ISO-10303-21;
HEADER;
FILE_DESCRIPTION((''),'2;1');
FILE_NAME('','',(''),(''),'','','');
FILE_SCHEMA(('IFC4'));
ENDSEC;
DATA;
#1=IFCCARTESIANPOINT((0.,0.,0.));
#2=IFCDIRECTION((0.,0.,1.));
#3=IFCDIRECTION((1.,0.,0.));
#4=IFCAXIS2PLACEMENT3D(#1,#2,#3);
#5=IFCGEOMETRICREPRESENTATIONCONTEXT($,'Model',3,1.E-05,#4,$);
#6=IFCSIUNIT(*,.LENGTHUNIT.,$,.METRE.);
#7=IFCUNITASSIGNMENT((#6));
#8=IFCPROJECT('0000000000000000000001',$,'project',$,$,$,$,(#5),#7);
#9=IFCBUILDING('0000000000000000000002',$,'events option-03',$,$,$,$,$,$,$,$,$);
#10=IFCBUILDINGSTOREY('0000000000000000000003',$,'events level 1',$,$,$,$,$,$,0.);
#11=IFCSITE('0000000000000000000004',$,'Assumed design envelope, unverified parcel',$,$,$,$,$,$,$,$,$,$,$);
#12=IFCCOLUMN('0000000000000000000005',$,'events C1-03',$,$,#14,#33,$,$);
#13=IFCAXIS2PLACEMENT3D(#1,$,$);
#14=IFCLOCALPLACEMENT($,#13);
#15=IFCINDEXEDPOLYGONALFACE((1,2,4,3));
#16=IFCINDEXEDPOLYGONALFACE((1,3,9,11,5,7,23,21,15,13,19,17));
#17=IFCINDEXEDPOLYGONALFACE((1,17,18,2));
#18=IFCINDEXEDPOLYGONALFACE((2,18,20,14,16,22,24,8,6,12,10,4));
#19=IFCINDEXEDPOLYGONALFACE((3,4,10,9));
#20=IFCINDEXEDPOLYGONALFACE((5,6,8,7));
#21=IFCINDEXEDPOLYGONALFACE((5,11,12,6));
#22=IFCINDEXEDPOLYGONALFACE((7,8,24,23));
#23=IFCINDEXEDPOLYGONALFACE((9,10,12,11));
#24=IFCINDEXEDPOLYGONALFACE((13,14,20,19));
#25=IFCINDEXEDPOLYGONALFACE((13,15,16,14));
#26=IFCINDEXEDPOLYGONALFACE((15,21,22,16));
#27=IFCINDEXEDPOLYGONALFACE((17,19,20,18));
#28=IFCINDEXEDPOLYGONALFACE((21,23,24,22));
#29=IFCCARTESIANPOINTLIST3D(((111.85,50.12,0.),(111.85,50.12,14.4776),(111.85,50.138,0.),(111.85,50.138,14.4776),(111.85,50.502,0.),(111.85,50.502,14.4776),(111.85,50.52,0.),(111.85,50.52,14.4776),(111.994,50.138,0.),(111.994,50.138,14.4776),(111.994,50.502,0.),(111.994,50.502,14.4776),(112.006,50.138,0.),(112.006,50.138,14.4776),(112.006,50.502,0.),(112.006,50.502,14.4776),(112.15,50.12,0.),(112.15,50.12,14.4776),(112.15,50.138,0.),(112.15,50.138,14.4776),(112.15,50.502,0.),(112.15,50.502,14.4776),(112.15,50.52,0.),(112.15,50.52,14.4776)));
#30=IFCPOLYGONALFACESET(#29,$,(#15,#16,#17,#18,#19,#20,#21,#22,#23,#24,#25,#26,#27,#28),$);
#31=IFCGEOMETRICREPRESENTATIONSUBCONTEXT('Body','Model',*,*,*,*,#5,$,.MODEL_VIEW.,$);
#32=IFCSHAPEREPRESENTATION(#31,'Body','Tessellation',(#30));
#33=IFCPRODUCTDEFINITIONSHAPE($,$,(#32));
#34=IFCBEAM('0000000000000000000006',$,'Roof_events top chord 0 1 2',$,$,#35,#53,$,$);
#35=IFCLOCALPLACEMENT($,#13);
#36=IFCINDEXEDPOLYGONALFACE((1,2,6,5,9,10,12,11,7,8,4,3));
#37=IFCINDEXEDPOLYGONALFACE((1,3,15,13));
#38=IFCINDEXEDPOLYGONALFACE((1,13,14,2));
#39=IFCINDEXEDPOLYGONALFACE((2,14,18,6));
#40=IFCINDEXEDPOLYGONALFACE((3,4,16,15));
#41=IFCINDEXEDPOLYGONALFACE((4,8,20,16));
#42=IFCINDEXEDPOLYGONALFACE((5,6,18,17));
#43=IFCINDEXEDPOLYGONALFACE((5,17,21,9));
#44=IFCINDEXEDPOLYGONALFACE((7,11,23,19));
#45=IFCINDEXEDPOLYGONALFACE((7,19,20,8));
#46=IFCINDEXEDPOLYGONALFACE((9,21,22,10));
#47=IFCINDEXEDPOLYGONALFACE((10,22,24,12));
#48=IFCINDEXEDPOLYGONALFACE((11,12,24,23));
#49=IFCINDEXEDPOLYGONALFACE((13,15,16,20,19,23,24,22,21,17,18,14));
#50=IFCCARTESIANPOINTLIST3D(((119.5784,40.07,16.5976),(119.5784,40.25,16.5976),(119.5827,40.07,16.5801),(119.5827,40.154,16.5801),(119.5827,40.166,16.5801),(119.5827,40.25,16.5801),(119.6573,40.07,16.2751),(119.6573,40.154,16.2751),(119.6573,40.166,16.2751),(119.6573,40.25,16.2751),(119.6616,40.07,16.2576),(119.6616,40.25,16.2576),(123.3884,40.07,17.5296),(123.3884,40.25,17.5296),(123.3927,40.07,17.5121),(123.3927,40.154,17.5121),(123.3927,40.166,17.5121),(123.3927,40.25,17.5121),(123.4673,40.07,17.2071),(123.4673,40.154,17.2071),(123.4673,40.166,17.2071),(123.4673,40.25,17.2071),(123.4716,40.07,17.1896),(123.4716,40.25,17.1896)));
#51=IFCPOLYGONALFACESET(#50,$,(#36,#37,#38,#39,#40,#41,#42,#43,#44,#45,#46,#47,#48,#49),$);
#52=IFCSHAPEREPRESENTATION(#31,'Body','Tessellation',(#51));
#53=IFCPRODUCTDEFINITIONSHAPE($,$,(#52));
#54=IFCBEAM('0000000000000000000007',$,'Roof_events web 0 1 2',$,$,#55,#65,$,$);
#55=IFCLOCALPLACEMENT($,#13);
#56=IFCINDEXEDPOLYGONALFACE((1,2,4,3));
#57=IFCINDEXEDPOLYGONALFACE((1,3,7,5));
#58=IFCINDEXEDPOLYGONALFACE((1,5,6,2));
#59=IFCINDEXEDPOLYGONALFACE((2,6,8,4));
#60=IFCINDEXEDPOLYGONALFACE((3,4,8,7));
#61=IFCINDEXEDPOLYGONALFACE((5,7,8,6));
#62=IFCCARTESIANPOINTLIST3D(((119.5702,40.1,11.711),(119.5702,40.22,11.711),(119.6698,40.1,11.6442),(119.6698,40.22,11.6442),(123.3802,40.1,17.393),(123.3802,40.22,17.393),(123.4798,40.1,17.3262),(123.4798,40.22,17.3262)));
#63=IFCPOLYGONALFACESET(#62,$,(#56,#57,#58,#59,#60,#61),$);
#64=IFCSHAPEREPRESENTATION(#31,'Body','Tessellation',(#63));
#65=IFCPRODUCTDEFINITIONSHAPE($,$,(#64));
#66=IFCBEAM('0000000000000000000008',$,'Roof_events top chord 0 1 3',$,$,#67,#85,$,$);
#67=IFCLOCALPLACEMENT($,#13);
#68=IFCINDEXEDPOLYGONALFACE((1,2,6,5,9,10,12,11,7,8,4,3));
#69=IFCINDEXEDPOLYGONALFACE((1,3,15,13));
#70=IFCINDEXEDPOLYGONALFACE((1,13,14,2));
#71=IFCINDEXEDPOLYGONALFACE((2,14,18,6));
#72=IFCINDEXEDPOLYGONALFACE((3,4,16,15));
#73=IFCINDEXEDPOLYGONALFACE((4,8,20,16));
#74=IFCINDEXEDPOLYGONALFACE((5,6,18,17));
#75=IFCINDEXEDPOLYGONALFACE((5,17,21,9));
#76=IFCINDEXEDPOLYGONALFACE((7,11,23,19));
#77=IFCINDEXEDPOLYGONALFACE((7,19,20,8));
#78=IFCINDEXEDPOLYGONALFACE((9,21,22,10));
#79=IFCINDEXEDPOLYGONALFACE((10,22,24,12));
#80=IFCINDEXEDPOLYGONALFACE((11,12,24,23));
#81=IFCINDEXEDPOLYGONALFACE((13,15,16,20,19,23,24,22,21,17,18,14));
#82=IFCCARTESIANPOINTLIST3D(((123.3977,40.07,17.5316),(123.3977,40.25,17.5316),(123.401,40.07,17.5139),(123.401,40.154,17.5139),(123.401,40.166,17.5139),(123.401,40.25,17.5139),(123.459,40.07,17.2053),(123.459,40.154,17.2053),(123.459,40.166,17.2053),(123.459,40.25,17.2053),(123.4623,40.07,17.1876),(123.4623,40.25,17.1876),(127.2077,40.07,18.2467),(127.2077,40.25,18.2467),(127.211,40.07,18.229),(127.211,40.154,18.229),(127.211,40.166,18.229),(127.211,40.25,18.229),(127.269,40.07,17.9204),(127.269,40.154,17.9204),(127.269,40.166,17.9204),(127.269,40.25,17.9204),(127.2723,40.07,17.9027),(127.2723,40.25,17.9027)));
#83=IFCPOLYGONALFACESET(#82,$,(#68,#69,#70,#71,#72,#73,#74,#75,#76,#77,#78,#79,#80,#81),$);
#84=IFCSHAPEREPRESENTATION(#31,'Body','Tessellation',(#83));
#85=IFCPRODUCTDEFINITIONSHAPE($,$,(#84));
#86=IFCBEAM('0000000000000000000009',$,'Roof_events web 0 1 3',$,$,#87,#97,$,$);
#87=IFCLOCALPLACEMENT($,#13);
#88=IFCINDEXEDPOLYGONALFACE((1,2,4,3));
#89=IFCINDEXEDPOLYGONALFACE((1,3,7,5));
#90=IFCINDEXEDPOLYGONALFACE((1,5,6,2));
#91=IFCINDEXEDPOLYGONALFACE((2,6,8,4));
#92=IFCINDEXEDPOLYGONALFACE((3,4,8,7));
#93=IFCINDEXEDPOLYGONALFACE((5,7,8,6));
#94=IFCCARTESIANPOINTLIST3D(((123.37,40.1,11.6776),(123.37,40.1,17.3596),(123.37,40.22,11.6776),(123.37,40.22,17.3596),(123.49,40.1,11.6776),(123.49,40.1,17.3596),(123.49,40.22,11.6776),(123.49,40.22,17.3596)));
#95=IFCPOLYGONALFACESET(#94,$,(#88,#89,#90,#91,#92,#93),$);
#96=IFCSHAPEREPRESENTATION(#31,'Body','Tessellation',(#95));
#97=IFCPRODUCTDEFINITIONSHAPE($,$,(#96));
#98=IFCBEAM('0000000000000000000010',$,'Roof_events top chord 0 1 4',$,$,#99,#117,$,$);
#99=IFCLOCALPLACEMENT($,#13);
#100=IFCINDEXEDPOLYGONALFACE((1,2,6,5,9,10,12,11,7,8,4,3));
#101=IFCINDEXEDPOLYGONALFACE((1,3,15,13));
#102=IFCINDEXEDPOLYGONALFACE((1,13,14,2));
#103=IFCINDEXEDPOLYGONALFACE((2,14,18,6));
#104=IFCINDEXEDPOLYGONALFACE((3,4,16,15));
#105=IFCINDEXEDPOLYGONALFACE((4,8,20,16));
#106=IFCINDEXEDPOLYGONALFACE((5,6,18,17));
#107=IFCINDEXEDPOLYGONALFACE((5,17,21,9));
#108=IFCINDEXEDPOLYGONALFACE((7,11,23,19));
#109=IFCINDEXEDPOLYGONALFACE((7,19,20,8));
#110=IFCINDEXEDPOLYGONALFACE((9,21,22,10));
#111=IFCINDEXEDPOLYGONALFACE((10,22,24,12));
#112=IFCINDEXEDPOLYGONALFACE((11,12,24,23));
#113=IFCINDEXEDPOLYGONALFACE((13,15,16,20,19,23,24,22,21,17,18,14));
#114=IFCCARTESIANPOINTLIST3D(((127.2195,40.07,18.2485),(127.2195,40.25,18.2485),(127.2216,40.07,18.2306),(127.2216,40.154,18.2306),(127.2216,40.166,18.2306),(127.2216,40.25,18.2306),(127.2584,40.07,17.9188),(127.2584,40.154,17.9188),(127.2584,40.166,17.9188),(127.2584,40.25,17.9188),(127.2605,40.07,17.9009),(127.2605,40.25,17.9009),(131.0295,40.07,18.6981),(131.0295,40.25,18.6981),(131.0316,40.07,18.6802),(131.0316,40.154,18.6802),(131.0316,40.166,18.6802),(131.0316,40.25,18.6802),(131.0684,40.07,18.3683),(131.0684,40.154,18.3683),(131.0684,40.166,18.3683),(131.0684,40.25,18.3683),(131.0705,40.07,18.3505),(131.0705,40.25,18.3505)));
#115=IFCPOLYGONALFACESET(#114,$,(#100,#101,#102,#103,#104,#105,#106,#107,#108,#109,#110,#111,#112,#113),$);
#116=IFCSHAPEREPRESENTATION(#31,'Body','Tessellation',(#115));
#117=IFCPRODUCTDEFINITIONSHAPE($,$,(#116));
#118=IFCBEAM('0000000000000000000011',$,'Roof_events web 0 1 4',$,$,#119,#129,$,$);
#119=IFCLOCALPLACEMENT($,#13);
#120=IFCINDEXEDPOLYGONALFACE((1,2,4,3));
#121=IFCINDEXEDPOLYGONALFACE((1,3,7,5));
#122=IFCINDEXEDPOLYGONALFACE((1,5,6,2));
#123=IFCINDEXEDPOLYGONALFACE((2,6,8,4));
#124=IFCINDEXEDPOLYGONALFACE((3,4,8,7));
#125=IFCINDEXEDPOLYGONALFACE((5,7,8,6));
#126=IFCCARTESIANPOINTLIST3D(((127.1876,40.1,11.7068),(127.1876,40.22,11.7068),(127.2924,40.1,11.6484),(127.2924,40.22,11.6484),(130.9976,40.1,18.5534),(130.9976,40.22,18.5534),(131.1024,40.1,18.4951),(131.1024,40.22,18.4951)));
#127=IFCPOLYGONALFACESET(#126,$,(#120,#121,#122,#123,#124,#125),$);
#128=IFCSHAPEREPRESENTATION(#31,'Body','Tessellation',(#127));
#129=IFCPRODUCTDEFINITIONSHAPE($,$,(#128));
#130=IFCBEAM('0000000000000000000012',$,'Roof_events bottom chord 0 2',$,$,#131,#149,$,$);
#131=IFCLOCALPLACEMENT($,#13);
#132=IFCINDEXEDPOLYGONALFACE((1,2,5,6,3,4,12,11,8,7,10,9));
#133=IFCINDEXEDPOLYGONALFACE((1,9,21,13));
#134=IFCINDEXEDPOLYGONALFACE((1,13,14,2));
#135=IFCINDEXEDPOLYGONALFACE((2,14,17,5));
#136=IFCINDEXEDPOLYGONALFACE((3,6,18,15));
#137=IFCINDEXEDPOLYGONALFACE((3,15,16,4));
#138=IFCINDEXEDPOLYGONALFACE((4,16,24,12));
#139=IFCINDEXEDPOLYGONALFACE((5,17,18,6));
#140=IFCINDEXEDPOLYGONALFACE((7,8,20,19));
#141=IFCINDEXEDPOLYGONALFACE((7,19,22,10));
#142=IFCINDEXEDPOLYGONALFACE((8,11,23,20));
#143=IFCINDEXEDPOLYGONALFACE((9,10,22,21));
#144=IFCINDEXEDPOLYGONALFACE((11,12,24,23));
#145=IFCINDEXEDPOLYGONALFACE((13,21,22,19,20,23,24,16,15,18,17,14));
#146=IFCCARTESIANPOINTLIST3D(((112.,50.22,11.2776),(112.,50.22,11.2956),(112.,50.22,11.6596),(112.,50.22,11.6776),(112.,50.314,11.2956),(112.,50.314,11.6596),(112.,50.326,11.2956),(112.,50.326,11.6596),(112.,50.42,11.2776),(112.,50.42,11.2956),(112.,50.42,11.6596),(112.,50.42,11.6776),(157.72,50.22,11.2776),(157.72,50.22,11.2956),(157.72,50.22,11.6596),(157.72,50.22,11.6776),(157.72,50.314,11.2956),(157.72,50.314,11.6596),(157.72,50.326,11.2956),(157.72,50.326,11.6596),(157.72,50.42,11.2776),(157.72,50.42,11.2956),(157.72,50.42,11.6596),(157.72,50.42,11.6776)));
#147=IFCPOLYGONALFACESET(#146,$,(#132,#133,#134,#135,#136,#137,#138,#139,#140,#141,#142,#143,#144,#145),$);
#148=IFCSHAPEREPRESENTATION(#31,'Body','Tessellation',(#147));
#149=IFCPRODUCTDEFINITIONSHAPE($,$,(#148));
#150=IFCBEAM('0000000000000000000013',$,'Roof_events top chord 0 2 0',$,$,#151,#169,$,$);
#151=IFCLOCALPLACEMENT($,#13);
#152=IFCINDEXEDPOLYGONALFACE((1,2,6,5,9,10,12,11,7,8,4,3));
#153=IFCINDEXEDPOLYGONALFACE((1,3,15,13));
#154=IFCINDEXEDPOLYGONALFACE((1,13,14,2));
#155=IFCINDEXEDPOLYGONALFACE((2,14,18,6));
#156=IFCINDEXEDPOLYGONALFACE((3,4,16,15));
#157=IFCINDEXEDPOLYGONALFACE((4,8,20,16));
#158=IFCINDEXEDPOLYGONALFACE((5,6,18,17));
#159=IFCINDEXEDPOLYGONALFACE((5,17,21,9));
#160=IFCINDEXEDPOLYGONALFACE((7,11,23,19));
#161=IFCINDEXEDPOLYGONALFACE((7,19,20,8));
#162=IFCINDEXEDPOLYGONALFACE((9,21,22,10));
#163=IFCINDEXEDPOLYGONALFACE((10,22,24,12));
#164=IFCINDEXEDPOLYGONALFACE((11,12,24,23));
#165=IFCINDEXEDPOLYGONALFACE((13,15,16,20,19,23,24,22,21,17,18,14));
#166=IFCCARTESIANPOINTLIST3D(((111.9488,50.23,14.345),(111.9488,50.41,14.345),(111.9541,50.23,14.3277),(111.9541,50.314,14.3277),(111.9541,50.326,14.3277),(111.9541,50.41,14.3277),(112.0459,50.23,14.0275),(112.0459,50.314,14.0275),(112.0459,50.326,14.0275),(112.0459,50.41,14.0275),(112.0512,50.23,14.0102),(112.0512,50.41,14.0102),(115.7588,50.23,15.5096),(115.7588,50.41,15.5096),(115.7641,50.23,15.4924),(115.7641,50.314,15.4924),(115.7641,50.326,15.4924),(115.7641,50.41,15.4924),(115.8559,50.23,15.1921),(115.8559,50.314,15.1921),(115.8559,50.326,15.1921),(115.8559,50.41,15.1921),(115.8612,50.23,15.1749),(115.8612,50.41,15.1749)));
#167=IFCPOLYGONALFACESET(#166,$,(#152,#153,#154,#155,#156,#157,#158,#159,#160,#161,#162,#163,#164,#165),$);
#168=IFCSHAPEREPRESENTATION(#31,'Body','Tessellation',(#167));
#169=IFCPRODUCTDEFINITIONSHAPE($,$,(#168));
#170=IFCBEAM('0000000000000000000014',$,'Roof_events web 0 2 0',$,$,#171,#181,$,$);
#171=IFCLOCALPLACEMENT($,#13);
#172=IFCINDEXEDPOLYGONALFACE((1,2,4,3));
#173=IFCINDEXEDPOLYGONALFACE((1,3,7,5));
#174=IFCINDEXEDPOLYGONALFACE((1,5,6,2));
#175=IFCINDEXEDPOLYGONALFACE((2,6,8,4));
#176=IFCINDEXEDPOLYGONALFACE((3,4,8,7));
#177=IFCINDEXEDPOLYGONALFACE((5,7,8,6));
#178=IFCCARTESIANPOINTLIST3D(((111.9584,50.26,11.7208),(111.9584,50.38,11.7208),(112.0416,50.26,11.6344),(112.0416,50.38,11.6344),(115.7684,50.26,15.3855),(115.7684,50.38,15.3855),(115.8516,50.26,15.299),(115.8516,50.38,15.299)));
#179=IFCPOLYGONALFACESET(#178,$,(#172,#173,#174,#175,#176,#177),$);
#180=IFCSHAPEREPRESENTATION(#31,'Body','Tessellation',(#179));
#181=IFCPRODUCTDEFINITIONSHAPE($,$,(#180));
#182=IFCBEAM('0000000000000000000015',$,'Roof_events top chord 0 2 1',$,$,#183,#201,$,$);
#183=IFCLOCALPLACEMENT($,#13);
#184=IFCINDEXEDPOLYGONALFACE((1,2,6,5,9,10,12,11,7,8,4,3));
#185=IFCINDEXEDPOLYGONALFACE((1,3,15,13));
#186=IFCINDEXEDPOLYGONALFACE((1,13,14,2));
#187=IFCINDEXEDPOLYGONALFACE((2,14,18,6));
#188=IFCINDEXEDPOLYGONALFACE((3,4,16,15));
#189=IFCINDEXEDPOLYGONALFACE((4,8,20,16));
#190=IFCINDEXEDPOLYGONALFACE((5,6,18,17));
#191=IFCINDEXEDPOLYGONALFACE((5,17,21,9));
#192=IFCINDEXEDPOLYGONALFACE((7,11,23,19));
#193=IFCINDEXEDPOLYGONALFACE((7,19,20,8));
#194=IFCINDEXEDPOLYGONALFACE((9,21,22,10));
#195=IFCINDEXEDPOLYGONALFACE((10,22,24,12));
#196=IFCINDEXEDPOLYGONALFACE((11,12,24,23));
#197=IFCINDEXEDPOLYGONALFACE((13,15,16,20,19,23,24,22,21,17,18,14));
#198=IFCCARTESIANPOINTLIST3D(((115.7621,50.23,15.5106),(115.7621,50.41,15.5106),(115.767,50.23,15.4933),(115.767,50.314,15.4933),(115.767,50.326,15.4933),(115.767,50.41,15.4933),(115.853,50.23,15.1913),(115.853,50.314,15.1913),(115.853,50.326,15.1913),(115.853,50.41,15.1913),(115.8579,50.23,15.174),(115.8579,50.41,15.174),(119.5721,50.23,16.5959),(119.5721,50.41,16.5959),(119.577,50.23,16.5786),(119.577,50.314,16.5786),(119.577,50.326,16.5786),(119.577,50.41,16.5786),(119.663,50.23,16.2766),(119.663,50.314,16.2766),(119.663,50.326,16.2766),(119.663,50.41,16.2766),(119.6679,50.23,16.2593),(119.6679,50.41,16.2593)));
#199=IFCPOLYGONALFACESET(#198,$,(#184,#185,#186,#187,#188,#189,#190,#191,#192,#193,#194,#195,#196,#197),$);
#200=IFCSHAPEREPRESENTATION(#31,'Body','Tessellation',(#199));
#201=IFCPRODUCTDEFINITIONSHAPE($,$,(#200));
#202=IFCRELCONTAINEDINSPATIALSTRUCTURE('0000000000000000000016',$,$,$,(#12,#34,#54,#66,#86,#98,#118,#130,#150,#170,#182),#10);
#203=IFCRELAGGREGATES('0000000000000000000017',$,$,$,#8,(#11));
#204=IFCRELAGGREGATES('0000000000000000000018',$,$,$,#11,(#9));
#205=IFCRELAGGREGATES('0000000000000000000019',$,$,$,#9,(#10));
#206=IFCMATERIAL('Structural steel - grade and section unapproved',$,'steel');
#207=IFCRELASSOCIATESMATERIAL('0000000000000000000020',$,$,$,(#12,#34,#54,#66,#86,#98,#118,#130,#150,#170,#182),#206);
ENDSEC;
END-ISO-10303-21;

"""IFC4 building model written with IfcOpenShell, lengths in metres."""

from ifc_helpers import new_model, si_unit, frame, origin_with_axes, place, context, subcontext, project, spatial, rectangle, i_section, extrude, material, element, save


model = new_model("IFC4")

# Units and contexts
model_context = context("Model", 3, precision=1e-05, world=origin_with_axes())
body_context = subcontext(model_context, "Body", "Model", "MODEL_VIEW")
ifc_project = project(units=[si_unit("LENGTHUNIT", "METRE")], contexts=[model_context])

# Site, building, storey
site = spatial("IfcSite", under=ifc_project, Name="Assumed design envelope, unverified parcel")
building = spatial("IfcBuilding", under=site, Name="events option-03")
storey = spatial("IfcBuildingStorey", under=building, Name="events level 1", Elevation=0.0)

# Column
ifc_material_1 = material(Name="Structural steel - grade and section unapproved", Category="steel")
column_placement = place(None, frame((112.0, 50.32, 0.0), z_axis=(0.0, 0.0, 1.0), x_axis=(-1.0, 0.0, 0.0)))
element("IfcColumn", 1, at=column_placement, inside=storey, material=ifc_material_1, Name="events C1-03", context=body_context, shape_type="SweptSolid", body=[
    extrude(i_section(OverallWidth=0.3, OverallDepth=0.4, WebThickness=0.012, FlangeThickness=0.018, FilletRadius=0.0), origin_with_axes(), (0.0, 0.0, 1.0), 14.4776),
])

# Beams
beam_1_placement = place(None, frame((119.62, 40.16, 16.4276), z_axis=(0.971361, 0.0, 0.237609), x_axis=(0.0, 1.0, 0.0)))
element("IfcBeam", 2, at=beam_1_placement, inside=storey, material=ifc_material_1, Name="Roof_events top chord 0 1 2", context=body_context, shape_type="SweptSolid", body=[
    extrude(i_section(OverallWidth=0.18, OverallDepth=0.35, WebThickness=0.012, FlangeThickness=0.018, FilletRadius=0.0), origin_with_axes(), (0.0, 0.0, 1.0), 3.9223),
])
beam_2_placement = place(None, frame((119.62, 40.16, 11.6776), z_axis=(0.556926, 0.0, 0.830562), x_axis=(0.0, 1.0, 0.0)))
element("IfcBeam", 3, at=beam_2_placement, inside=storey, material=ifc_material_1, Name="Roof_events web 0 1 2", context=body_context, shape_type="SweptSolid", body=[
    extrude(rectangle(XDim=0.12, YDim=0.12), origin_with_axes(), (0.0, 0.0, 1.0), 6.8411),
])
beam_3_placement = place(None, frame((123.43, 40.16, 17.3596), z_axis=(0.982837, 0.0, 0.184478), x_axis=(0.0, 1.0, 0.0)))
element("IfcBeam", 4, at=beam_3_placement, inside=storey, material=ifc_material_1, Name="Roof_events top chord 0 1 3", context=body_context, shape_type="SweptSolid", body=[
    extrude(i_section(OverallWidth=0.18, OverallDepth=0.35, WebThickness=0.012, FlangeThickness=0.018, FilletRadius=0.0), origin_with_axes(), (0.0, 0.0, 1.0), 3.8765),
])
beam_4_placement = place(None, frame((123.43, 40.16, 11.6776), z_axis=(0.0, 0.0, 1.0), x_axis=(-1.0, 0.0, 0.0)))
element("IfcBeam", 5, at=beam_4_placement, inside=storey, material=ifc_material_1, Name="Roof_events web 0 1 3", context=body_context, shape_type="SweptSolid", body=[
    extrude(rectangle(XDim=0.12, YDim=0.12), origin_with_axes(), (0.0, 0.0, 1.0), 5.682),
])
beam_5_placement = place(None, frame((127.24, 40.16, 18.0747), z_axis=(0.993111, 0.0, 0.117179), x_axis=(0.0, 1.0, 0.0)))
element("IfcBeam", 6, at=beam_5_placement, inside=storey, material=ifc_material_1, Name="Roof_events top chord 0 1 4", context=body_context, shape_type="SweptSolid", body=[
    extrude(i_section(OverallWidth=0.18, OverallDepth=0.35, WebThickness=0.012, FlangeThickness=0.018, FilletRadius=0.0), origin_with_axes(), (0.0, 0.0, 1.0), 3.8364),
])
beam_6_placement = place(None, frame((127.24, 40.16, 11.6776), z_axis=(0.486257, 0.0, 0.873816), x_axis=(0.0, 1.0, 0.0)))
element("IfcBeam", 7, at=beam_6_placement, inside=storey, material=ifc_material_1, Name="Roof_events web 0 1 4", context=body_context, shape_type="SweptSolid", body=[
    extrude(rectangle(XDim=0.12, YDim=0.12), origin_with_axes(), (0.0, 0.0, 1.0), 7.8354),
])
beam_7_placement = place(None, frame((112.0, 50.32, 11.4776), z_axis=(1.0, 0.0, 0.0), x_axis=(0.0, 1.0, 0.0)))
element("IfcBeam", 8, at=beam_7_placement, inside=storey, material=ifc_material_1, Name="Roof_events bottom chord 0 2", context=body_context, shape_type="SweptSolid", body=[
    extrude(i_section(OverallWidth=0.2, OverallDepth=0.4, WebThickness=0.012, FlangeThickness=0.018, FilletRadius=0.0), origin_with_axes(), (0.0, 0.0, 1.0), 45.72),
])
beam_8_placement = place(None, frame((112.0, 50.32, 14.1776), z_axis=(0.956315, 0.0, 0.292338), x_axis=(0.0, 1.0, 0.0)))
element("IfcBeam", 9, at=beam_8_placement, inside=storey, material=ifc_material_1, Name="Roof_events top chord 0 2 0", context=body_context, shape_type="SweptSolid", body=[
    extrude(i_section(OverallWidth=0.18, OverallDepth=0.35, WebThickness=0.012, FlangeThickness=0.018, FilletRadius=0.0), origin_with_axes(), (0.0, 0.0, 1.0), 3.984),
])
beam_9_placement = place(None, frame((112.0, 50.32, 11.6776), z_axis=(0.720717, 0.0, 0.693229), x_axis=(0.0, 1.0, 0.0)))
element("IfcBeam", 10, at=beam_9_placement, inside=storey, material=ifc_material_1, Name="Roof_events web 0 2 0", context=body_context, shape_type="SweptSolid", body=[
    extrude(rectangle(XDim=0.12, YDim=0.12), origin_with_axes(), (0.0, 0.0, 1.0), 5.2864),
])
beam_10_placement = place(None, frame((115.81, 50.32, 15.3423), z_axis=(0.961741, 0.0, 0.27396), x_axis=(0.0, 1.0, 0.0)))
element("IfcBeam", 11, at=beam_10_placement, inside=storey, material=ifc_material_1, Name="Roof_events top chord 0 2 1", context=body_context, shape_type="SweptSolid", body=[
    extrude(i_section(OverallWidth=0.18, OverallDepth=0.35, WebThickness=0.012, FlangeThickness=0.018, FilletRadius=0.0), origin_with_axes(), (0.0, 0.0, 1.0), 3.9616),
])

save(model, "model.ifc")
